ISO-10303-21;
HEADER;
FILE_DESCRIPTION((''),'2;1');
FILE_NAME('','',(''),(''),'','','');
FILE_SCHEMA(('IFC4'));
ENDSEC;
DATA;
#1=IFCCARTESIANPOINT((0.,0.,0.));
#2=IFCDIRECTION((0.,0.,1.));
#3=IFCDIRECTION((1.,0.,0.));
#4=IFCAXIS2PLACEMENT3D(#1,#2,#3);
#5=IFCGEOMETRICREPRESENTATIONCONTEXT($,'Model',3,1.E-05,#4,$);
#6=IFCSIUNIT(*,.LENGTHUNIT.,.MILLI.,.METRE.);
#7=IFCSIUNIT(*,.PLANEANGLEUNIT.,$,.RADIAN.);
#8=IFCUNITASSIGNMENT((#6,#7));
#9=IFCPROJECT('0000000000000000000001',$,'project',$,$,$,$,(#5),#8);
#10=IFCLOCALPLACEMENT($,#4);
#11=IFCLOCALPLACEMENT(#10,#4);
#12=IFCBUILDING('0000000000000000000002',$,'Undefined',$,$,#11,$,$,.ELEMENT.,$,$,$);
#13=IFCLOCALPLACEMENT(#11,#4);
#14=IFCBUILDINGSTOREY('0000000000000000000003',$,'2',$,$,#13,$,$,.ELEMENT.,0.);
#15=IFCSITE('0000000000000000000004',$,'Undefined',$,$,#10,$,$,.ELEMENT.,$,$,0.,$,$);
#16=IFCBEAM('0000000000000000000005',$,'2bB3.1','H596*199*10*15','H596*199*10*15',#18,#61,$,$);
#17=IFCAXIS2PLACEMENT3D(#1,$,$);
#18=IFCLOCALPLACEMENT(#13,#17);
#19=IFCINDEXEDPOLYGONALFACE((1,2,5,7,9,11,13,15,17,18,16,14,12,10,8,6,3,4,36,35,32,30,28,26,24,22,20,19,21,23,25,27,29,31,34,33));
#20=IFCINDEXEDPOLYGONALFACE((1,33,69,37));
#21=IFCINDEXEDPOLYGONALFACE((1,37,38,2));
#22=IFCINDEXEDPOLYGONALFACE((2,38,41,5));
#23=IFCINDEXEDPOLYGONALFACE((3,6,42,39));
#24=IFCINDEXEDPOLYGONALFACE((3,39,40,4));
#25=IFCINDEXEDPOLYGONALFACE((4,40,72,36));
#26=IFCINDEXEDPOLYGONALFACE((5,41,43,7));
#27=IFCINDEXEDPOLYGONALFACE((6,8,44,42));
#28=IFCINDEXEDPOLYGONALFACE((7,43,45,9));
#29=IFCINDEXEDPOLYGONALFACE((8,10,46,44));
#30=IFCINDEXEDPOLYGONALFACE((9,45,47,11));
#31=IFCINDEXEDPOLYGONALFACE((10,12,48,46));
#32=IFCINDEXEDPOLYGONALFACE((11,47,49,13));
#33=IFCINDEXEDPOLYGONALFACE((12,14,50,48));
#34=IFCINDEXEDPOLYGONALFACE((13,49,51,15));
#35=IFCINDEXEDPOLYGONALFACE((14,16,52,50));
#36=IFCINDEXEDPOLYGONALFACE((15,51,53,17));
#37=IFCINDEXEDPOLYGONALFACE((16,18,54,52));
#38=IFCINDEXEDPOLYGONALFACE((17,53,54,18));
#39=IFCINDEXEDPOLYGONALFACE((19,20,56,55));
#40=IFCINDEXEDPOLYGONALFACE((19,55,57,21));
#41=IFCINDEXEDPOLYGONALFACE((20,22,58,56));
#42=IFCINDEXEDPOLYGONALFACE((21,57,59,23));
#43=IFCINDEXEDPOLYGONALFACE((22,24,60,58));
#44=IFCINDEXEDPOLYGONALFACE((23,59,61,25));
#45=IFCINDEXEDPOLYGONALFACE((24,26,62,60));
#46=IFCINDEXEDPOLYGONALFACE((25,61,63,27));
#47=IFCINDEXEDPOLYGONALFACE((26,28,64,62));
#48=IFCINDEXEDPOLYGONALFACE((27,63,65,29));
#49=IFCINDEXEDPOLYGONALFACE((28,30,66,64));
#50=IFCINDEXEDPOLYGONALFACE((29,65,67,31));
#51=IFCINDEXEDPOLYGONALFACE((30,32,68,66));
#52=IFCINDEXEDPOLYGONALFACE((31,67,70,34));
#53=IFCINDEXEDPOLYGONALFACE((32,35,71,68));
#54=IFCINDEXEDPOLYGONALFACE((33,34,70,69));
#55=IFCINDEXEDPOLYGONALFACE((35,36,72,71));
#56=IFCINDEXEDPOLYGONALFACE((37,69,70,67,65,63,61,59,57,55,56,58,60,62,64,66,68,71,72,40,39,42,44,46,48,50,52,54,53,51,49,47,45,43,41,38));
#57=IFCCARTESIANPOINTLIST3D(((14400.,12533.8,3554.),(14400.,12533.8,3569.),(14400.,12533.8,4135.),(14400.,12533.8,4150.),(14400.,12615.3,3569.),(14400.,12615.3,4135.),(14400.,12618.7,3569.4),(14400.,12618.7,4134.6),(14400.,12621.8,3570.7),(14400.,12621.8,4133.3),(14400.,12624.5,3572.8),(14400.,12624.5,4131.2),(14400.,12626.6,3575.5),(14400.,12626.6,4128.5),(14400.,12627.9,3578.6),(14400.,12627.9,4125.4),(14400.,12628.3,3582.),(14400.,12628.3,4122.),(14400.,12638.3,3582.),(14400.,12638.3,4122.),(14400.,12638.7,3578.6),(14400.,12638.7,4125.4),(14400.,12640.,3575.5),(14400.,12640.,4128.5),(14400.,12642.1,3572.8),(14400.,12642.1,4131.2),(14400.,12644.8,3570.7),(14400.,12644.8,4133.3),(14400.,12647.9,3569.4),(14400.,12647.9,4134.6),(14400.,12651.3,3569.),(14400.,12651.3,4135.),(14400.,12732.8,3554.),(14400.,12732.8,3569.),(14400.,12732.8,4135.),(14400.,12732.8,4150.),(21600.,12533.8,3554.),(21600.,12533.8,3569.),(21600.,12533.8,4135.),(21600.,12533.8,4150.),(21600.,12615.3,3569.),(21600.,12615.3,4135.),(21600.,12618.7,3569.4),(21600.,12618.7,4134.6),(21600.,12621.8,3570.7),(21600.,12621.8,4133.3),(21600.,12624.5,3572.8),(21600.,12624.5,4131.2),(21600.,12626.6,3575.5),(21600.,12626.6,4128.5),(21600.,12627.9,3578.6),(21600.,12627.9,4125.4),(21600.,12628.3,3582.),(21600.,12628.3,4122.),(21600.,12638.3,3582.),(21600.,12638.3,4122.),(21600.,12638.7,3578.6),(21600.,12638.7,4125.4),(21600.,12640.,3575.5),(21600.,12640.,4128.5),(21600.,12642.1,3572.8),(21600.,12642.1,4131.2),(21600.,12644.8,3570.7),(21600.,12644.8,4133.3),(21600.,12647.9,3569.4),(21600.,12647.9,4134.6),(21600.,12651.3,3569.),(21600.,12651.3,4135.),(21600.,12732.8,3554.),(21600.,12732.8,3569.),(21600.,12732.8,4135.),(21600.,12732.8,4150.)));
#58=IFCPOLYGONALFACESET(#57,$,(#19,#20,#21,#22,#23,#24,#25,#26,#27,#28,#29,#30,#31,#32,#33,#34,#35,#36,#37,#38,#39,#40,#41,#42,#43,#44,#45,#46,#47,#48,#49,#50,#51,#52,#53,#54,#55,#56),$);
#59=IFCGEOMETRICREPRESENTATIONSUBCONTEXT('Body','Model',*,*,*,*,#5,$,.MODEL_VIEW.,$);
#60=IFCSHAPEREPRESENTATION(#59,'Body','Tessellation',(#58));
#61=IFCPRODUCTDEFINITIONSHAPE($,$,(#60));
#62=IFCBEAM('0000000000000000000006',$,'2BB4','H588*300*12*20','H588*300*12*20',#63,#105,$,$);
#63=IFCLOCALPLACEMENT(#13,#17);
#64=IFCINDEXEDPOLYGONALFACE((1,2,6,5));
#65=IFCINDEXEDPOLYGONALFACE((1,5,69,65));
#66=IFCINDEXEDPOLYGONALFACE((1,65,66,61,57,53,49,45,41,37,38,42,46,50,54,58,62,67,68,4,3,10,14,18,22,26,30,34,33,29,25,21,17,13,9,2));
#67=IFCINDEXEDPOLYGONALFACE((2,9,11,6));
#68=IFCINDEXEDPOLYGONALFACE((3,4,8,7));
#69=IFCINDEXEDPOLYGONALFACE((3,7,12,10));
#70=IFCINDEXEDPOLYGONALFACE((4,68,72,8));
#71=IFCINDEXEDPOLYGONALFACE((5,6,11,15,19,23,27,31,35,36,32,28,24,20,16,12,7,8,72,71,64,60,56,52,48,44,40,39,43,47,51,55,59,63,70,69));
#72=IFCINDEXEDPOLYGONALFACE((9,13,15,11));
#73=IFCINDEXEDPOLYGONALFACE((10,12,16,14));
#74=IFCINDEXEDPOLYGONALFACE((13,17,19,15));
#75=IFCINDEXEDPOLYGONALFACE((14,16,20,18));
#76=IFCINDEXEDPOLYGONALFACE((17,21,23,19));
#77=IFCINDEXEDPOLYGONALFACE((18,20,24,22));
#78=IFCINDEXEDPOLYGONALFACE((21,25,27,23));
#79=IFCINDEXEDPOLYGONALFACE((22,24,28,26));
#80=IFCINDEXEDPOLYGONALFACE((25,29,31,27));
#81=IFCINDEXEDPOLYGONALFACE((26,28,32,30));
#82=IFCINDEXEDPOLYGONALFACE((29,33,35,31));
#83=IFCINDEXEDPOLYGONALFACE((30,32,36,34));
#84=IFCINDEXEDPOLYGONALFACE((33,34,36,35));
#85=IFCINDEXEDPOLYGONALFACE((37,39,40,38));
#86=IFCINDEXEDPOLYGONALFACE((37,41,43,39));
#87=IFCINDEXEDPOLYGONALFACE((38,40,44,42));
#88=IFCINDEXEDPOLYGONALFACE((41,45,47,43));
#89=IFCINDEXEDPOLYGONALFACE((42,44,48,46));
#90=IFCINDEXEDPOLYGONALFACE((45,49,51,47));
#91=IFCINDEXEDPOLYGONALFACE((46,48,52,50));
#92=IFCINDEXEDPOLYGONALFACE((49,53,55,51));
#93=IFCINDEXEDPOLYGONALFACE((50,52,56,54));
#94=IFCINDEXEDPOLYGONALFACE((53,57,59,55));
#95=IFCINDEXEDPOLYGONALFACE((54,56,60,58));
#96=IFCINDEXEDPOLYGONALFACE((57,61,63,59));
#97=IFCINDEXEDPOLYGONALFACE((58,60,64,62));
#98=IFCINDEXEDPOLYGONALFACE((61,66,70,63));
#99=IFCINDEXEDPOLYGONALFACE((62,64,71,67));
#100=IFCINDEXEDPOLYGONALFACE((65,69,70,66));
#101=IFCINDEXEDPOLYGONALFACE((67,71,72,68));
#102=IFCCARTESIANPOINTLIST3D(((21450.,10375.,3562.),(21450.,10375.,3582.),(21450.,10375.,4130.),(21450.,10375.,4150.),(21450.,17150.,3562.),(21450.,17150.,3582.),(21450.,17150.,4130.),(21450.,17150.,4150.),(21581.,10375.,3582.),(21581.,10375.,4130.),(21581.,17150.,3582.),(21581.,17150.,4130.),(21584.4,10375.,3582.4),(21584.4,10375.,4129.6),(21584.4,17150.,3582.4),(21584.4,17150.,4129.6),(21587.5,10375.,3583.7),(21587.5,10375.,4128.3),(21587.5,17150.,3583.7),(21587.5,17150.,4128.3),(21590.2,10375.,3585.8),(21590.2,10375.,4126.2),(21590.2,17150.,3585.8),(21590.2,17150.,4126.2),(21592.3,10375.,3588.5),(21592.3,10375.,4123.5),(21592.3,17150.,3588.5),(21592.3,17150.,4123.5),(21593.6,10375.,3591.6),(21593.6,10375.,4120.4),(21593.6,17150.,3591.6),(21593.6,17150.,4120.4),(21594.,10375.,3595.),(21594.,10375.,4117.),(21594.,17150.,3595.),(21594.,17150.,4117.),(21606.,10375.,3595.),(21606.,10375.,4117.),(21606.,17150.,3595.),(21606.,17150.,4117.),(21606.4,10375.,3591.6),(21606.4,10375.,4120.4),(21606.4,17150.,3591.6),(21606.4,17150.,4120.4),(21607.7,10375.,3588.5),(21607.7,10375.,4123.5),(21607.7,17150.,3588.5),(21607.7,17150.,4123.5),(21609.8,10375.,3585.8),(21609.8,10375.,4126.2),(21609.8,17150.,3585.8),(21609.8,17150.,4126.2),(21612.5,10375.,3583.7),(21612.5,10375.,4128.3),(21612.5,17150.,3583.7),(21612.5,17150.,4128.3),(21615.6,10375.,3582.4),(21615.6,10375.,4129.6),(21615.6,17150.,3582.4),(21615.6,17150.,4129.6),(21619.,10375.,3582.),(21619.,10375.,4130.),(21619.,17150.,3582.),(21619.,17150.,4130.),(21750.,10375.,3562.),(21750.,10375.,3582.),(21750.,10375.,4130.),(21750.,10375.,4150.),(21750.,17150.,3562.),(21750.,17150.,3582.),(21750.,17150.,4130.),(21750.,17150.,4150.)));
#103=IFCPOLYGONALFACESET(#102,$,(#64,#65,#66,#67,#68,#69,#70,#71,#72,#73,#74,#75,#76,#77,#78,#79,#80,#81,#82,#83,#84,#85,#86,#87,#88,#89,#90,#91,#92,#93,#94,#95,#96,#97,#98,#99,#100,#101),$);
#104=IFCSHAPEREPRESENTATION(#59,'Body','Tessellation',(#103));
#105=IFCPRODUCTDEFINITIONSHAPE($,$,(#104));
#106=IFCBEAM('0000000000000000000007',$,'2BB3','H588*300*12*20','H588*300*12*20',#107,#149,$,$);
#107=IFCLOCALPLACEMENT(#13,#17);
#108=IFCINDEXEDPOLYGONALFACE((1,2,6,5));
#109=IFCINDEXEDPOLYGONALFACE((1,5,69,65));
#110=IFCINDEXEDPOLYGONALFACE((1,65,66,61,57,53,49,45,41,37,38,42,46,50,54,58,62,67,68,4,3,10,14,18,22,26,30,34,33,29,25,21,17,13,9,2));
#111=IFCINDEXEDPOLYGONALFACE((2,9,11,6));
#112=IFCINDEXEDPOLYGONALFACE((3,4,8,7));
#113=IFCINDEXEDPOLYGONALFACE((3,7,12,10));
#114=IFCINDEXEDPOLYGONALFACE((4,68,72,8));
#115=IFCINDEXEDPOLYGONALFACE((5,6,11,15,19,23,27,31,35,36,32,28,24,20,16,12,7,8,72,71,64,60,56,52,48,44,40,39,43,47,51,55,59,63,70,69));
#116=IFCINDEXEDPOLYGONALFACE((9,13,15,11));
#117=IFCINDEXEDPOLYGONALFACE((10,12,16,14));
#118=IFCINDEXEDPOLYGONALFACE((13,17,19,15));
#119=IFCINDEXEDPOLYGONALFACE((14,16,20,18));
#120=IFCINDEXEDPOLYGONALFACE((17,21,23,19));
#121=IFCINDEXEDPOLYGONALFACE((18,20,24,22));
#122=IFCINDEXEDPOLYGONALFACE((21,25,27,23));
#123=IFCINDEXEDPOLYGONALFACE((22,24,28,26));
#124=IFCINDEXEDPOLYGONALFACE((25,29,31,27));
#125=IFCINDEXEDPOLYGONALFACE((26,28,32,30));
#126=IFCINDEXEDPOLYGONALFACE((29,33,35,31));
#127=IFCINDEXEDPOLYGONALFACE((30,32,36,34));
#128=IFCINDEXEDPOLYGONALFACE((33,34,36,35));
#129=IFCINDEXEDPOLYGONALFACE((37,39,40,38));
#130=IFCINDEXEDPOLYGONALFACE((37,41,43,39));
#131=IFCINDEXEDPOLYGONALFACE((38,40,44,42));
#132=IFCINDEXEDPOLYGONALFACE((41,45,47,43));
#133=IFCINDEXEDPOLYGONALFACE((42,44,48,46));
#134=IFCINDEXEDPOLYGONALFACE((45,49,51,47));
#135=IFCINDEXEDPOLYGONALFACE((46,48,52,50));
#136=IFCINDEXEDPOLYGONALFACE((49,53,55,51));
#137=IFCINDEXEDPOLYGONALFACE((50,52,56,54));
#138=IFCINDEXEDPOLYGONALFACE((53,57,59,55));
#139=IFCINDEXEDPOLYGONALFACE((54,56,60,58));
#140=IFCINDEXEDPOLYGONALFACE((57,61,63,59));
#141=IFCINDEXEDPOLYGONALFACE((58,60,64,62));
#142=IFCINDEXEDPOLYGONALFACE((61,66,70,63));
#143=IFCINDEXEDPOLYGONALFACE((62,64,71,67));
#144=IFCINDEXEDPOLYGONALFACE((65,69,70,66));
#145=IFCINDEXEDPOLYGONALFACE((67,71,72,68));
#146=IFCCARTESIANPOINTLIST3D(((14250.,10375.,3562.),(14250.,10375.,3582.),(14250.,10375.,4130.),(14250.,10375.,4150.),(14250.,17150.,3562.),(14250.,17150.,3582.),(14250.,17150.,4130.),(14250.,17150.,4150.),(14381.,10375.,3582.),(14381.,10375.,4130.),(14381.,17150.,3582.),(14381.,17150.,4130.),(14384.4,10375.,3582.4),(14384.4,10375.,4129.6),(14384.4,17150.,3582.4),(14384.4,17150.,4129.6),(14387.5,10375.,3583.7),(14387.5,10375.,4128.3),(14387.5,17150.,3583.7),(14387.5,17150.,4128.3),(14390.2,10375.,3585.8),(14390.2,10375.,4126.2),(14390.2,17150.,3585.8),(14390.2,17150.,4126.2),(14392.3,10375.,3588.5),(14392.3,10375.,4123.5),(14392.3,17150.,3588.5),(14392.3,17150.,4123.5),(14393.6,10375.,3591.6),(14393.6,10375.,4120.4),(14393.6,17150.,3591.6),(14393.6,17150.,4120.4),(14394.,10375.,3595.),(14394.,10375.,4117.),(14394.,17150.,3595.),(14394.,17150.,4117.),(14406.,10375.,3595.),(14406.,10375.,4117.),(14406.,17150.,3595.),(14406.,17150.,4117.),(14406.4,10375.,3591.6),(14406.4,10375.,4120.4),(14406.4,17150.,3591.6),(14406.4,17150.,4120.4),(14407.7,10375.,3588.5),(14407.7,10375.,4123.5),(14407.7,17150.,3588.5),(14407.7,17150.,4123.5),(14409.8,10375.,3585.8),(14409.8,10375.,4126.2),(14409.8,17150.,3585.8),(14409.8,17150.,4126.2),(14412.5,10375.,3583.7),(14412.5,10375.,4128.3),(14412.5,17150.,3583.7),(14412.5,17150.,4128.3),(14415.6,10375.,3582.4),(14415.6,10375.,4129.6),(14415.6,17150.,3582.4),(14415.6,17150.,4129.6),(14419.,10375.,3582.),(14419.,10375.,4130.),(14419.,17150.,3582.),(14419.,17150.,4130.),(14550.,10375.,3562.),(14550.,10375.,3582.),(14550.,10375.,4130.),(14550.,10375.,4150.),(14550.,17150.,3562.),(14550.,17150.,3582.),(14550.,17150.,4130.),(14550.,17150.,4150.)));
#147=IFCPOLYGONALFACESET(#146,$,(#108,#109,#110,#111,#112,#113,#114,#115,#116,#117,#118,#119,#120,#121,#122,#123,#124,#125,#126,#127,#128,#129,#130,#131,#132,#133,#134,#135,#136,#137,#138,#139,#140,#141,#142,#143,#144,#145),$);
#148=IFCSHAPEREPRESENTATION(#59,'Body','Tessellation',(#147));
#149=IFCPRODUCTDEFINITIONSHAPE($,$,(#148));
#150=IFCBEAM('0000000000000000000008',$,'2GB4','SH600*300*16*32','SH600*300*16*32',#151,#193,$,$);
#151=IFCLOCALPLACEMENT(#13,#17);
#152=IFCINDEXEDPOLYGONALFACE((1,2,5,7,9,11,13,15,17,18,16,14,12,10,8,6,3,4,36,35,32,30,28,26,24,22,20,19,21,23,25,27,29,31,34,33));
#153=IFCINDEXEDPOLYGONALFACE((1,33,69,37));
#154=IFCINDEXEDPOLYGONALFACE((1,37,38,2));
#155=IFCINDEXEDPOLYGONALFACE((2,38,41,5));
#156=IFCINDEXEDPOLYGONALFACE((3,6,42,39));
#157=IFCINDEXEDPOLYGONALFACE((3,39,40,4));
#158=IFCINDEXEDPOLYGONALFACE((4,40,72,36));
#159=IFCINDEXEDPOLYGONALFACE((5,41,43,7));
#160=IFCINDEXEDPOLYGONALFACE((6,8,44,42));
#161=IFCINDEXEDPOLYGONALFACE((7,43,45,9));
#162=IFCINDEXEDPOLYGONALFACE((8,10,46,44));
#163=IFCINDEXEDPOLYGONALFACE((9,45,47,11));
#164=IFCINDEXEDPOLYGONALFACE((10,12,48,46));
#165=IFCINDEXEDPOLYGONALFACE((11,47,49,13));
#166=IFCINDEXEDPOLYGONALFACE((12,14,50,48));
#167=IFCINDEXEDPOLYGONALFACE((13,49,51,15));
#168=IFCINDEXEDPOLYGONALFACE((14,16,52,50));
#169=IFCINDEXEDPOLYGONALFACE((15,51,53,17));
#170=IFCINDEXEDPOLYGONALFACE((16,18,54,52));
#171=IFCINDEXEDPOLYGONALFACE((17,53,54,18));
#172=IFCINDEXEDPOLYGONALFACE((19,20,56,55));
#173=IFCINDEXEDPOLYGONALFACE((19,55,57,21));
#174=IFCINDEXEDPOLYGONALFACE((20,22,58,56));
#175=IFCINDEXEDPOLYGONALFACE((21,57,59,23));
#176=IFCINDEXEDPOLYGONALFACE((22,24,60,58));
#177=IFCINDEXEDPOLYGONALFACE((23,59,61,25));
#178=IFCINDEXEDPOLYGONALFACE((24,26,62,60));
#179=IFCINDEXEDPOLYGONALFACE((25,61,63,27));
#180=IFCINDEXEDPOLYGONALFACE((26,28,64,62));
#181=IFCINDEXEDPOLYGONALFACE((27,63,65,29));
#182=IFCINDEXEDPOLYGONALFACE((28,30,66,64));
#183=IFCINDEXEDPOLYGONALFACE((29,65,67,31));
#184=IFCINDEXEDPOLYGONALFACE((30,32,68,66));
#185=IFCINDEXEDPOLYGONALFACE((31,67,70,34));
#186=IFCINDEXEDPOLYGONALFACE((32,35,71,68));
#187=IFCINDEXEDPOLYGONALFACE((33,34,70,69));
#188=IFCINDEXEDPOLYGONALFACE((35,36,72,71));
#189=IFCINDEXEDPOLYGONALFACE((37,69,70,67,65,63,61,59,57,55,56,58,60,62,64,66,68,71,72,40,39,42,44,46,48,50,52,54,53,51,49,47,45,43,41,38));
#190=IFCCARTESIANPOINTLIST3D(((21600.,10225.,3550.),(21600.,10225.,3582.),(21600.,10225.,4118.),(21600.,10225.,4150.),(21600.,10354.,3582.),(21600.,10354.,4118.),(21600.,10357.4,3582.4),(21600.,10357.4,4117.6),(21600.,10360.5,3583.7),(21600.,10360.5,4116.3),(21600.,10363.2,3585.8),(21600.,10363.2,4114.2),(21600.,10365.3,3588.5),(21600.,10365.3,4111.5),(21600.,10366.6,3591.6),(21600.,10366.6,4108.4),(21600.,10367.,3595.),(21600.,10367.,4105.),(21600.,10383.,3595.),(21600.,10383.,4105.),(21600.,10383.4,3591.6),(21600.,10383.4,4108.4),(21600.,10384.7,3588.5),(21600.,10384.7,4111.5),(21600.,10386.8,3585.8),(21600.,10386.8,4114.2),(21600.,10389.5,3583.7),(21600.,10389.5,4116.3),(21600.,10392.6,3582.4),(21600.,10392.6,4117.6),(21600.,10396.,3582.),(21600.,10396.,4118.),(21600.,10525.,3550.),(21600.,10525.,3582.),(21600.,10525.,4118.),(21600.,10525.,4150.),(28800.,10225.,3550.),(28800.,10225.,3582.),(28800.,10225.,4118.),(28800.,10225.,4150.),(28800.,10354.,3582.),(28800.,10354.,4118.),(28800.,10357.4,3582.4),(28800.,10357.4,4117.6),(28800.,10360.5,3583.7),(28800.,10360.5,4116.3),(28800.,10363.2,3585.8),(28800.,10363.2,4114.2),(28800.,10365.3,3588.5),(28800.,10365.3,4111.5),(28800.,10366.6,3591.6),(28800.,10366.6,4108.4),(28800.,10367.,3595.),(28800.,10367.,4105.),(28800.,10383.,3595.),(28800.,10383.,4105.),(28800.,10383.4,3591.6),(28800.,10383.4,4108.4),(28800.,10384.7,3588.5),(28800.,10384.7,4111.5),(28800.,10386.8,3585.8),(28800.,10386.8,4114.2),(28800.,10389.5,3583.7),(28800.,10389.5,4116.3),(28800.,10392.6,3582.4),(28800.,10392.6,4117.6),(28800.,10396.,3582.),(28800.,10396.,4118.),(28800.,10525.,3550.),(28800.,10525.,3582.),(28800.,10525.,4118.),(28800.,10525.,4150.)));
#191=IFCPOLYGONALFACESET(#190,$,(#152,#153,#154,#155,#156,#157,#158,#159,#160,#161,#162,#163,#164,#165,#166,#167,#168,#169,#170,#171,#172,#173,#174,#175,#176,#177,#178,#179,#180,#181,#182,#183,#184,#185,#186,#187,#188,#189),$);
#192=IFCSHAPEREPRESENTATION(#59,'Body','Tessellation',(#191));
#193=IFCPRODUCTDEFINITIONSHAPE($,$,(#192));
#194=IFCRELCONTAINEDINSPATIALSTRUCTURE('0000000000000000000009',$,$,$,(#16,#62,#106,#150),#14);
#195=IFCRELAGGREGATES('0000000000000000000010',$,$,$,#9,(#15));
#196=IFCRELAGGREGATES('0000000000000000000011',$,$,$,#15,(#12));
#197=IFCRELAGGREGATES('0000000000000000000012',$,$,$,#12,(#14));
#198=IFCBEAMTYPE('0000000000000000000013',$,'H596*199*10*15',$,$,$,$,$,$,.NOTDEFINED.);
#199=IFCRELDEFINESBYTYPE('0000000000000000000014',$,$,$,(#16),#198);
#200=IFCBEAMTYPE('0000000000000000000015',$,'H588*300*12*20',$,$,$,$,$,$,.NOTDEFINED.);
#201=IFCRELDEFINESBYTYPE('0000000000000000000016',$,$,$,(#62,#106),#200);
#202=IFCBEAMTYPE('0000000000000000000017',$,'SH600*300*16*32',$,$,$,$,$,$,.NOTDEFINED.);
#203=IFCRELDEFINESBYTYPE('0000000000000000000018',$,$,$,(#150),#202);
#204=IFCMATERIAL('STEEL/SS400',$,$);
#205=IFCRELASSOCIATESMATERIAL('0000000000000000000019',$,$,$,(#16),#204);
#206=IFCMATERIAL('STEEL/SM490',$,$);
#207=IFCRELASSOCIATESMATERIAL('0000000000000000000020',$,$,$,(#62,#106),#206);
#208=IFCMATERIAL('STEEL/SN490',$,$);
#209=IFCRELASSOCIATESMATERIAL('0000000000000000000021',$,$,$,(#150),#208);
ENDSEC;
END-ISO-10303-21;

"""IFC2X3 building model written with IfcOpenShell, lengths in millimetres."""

from ifc_helpers import new_model, si_unit, frame, origin_with_axes, origin_2d_with_axis, place, context, subcontext, project, spatial, i_section, extrude, material, type_object, element, save


model = new_model("IFC2X3")

# Units and contexts
model_context = context("Model", 3, precision=1e-05, world=origin_with_axes())
body_context = subcontext(model_context, "Body", "Model", "MODEL_VIEW")
ifc_project = project(units=[si_unit("LENGTHUNIT", "METRE", prefix="MILLI"), si_unit("PLANEANGLEUNIT", "RADIAN")], contexts=[model_context])

# Site, building, storey
site_placement = place(None, origin_with_axes())
site = spatial("IfcSite", under=ifc_project, at=site_placement, Name="Undefined", CompositionType="ELEMENT", RefElevation=0.0)
building_placement = place(site_placement, origin_with_axes())
building = spatial("IfcBuilding", under=site, at=building_placement, Name="Undefined", CompositionType="ELEMENT")
storey_placement = place(building_placement, origin_with_axes())
storey = spatial("IfcBuildingStorey", under=building, at=storey_placement, Name="2", CompositionType="ELEMENT", Elevation=0.0)

# Shared definitions
ifc_material_1 = material(Name="STEEL/SN490")
ifc_material_2 = material(Name="STEEL/SM490")

# Beams
ifc_material_3 = material(Name="STEEL/SS400")
beam_type_1 = type_object("IfcBeamType", Name="H596*199*10*15", PredefinedType="NOTDEFINED")
for number, where, z_axis, x_axis, name in (
    (1, (14400.0, 12633.3, 3852.0), (0.0, 0.0, 1.0), (1.0, 0.0, 0.0), "2bB3.1"),
):
    element("IfcBeam", number, at=place(storey_placement, frame(where, z_axis=z_axis, x_axis=x_axis)), inside=storey, type_object=beam_type_1, material=ifc_material_3, Name=name, Description="H596*199*10*15", ObjectType="H596*199*10*15", context=body_context, shape_type="SweptSolid", body=[
        extrude(i_section(OverallWidth=199.0, OverallDepth=596.0, WebThickness=10.0, FlangeThickness=15.0, FilletRadius=13.0, at=origin_2d_with_axis()), frame((7200.0, 0.0, 0.0), z_axis=(-1.0, 0.0, 0.0), x_axis=(0.0, -1.0, 0.0)), (0.0, 0.0, 1.0), 7200.0),
    ])
beam_type_2 = type_object("IfcBeamType", Name="H588*300*12*20", PredefinedType="NOTDEFINED")
for number, where, z_axis, x_axis, name in (
    (2, (21600.0, 10375.0, 3856.0), (0.0, 0.0, 1.0), (0.0, 1.0, 0.0), "2BB4"),
    (3, (14400.0, 10375.0, 3856.0), (0.0, 0.0, 1.0), (0.0, 1.0, 0.0), "2BB3"),
):
    element("IfcBeam", number, at=place(storey_placement, frame(where, z_axis=z_axis, x_axis=x_axis)), inside=storey, type_object=beam_type_2, material=ifc_material_2, Name=name, Description="H588*300*12*20", ObjectType="H588*300*12*20", context=body_context, shape_type="SweptSolid", body=[
        extrude(i_section(OverallWidth=300.0, OverallDepth=588.0, WebThickness=12.0, FlangeThickness=20.0, FilletRadius=13.0, at=origin_2d_with_axis()), frame((6775.0, 0.0, 0.0), z_axis=(-1.0, 0.0, 0.0), x_axis=(0.0, -1.0, 0.0)), (0.0, 0.0, 1.0), 6775.0),
    ])
beam_type_3 = type_object("IfcBeamType", Name="SH600*300*16*32", PredefinedType="NOTDEFINED")
for number, where, z_axis, x_axis, name in (
    (4, (21600.0, 10375.0, 3850.0), (0.0, 0.0, 1.0), (1.0, 0.0, 0.0), "2GB4"),
):
    element("IfcBeam", number, at=place(storey_placement, frame(where, z_axis=z_axis, x_axis=x_axis)), inside=storey, type_object=beam_type_3, material=ifc_material_1, Name=name, Description="SH600*300*16*32", ObjectType="SH600*300*16*32", context=body_context, shape_type="SweptSolid", body=[
        extrude(i_section(OverallWidth=300.0, OverallDepth=600.0, WebThickness=16.0, FlangeThickness=32.0, FilletRadius=13.0, at=origin_2d_with_axis()), frame((7200.0, 0.0, 0.0), z_axis=(-1.0, 0.0, 0.0), x_axis=(0.0, -1.0, 0.0)), (0.0, 0.0, 1.0), 7200.0),
    ])

save(model, "model.ifc")
